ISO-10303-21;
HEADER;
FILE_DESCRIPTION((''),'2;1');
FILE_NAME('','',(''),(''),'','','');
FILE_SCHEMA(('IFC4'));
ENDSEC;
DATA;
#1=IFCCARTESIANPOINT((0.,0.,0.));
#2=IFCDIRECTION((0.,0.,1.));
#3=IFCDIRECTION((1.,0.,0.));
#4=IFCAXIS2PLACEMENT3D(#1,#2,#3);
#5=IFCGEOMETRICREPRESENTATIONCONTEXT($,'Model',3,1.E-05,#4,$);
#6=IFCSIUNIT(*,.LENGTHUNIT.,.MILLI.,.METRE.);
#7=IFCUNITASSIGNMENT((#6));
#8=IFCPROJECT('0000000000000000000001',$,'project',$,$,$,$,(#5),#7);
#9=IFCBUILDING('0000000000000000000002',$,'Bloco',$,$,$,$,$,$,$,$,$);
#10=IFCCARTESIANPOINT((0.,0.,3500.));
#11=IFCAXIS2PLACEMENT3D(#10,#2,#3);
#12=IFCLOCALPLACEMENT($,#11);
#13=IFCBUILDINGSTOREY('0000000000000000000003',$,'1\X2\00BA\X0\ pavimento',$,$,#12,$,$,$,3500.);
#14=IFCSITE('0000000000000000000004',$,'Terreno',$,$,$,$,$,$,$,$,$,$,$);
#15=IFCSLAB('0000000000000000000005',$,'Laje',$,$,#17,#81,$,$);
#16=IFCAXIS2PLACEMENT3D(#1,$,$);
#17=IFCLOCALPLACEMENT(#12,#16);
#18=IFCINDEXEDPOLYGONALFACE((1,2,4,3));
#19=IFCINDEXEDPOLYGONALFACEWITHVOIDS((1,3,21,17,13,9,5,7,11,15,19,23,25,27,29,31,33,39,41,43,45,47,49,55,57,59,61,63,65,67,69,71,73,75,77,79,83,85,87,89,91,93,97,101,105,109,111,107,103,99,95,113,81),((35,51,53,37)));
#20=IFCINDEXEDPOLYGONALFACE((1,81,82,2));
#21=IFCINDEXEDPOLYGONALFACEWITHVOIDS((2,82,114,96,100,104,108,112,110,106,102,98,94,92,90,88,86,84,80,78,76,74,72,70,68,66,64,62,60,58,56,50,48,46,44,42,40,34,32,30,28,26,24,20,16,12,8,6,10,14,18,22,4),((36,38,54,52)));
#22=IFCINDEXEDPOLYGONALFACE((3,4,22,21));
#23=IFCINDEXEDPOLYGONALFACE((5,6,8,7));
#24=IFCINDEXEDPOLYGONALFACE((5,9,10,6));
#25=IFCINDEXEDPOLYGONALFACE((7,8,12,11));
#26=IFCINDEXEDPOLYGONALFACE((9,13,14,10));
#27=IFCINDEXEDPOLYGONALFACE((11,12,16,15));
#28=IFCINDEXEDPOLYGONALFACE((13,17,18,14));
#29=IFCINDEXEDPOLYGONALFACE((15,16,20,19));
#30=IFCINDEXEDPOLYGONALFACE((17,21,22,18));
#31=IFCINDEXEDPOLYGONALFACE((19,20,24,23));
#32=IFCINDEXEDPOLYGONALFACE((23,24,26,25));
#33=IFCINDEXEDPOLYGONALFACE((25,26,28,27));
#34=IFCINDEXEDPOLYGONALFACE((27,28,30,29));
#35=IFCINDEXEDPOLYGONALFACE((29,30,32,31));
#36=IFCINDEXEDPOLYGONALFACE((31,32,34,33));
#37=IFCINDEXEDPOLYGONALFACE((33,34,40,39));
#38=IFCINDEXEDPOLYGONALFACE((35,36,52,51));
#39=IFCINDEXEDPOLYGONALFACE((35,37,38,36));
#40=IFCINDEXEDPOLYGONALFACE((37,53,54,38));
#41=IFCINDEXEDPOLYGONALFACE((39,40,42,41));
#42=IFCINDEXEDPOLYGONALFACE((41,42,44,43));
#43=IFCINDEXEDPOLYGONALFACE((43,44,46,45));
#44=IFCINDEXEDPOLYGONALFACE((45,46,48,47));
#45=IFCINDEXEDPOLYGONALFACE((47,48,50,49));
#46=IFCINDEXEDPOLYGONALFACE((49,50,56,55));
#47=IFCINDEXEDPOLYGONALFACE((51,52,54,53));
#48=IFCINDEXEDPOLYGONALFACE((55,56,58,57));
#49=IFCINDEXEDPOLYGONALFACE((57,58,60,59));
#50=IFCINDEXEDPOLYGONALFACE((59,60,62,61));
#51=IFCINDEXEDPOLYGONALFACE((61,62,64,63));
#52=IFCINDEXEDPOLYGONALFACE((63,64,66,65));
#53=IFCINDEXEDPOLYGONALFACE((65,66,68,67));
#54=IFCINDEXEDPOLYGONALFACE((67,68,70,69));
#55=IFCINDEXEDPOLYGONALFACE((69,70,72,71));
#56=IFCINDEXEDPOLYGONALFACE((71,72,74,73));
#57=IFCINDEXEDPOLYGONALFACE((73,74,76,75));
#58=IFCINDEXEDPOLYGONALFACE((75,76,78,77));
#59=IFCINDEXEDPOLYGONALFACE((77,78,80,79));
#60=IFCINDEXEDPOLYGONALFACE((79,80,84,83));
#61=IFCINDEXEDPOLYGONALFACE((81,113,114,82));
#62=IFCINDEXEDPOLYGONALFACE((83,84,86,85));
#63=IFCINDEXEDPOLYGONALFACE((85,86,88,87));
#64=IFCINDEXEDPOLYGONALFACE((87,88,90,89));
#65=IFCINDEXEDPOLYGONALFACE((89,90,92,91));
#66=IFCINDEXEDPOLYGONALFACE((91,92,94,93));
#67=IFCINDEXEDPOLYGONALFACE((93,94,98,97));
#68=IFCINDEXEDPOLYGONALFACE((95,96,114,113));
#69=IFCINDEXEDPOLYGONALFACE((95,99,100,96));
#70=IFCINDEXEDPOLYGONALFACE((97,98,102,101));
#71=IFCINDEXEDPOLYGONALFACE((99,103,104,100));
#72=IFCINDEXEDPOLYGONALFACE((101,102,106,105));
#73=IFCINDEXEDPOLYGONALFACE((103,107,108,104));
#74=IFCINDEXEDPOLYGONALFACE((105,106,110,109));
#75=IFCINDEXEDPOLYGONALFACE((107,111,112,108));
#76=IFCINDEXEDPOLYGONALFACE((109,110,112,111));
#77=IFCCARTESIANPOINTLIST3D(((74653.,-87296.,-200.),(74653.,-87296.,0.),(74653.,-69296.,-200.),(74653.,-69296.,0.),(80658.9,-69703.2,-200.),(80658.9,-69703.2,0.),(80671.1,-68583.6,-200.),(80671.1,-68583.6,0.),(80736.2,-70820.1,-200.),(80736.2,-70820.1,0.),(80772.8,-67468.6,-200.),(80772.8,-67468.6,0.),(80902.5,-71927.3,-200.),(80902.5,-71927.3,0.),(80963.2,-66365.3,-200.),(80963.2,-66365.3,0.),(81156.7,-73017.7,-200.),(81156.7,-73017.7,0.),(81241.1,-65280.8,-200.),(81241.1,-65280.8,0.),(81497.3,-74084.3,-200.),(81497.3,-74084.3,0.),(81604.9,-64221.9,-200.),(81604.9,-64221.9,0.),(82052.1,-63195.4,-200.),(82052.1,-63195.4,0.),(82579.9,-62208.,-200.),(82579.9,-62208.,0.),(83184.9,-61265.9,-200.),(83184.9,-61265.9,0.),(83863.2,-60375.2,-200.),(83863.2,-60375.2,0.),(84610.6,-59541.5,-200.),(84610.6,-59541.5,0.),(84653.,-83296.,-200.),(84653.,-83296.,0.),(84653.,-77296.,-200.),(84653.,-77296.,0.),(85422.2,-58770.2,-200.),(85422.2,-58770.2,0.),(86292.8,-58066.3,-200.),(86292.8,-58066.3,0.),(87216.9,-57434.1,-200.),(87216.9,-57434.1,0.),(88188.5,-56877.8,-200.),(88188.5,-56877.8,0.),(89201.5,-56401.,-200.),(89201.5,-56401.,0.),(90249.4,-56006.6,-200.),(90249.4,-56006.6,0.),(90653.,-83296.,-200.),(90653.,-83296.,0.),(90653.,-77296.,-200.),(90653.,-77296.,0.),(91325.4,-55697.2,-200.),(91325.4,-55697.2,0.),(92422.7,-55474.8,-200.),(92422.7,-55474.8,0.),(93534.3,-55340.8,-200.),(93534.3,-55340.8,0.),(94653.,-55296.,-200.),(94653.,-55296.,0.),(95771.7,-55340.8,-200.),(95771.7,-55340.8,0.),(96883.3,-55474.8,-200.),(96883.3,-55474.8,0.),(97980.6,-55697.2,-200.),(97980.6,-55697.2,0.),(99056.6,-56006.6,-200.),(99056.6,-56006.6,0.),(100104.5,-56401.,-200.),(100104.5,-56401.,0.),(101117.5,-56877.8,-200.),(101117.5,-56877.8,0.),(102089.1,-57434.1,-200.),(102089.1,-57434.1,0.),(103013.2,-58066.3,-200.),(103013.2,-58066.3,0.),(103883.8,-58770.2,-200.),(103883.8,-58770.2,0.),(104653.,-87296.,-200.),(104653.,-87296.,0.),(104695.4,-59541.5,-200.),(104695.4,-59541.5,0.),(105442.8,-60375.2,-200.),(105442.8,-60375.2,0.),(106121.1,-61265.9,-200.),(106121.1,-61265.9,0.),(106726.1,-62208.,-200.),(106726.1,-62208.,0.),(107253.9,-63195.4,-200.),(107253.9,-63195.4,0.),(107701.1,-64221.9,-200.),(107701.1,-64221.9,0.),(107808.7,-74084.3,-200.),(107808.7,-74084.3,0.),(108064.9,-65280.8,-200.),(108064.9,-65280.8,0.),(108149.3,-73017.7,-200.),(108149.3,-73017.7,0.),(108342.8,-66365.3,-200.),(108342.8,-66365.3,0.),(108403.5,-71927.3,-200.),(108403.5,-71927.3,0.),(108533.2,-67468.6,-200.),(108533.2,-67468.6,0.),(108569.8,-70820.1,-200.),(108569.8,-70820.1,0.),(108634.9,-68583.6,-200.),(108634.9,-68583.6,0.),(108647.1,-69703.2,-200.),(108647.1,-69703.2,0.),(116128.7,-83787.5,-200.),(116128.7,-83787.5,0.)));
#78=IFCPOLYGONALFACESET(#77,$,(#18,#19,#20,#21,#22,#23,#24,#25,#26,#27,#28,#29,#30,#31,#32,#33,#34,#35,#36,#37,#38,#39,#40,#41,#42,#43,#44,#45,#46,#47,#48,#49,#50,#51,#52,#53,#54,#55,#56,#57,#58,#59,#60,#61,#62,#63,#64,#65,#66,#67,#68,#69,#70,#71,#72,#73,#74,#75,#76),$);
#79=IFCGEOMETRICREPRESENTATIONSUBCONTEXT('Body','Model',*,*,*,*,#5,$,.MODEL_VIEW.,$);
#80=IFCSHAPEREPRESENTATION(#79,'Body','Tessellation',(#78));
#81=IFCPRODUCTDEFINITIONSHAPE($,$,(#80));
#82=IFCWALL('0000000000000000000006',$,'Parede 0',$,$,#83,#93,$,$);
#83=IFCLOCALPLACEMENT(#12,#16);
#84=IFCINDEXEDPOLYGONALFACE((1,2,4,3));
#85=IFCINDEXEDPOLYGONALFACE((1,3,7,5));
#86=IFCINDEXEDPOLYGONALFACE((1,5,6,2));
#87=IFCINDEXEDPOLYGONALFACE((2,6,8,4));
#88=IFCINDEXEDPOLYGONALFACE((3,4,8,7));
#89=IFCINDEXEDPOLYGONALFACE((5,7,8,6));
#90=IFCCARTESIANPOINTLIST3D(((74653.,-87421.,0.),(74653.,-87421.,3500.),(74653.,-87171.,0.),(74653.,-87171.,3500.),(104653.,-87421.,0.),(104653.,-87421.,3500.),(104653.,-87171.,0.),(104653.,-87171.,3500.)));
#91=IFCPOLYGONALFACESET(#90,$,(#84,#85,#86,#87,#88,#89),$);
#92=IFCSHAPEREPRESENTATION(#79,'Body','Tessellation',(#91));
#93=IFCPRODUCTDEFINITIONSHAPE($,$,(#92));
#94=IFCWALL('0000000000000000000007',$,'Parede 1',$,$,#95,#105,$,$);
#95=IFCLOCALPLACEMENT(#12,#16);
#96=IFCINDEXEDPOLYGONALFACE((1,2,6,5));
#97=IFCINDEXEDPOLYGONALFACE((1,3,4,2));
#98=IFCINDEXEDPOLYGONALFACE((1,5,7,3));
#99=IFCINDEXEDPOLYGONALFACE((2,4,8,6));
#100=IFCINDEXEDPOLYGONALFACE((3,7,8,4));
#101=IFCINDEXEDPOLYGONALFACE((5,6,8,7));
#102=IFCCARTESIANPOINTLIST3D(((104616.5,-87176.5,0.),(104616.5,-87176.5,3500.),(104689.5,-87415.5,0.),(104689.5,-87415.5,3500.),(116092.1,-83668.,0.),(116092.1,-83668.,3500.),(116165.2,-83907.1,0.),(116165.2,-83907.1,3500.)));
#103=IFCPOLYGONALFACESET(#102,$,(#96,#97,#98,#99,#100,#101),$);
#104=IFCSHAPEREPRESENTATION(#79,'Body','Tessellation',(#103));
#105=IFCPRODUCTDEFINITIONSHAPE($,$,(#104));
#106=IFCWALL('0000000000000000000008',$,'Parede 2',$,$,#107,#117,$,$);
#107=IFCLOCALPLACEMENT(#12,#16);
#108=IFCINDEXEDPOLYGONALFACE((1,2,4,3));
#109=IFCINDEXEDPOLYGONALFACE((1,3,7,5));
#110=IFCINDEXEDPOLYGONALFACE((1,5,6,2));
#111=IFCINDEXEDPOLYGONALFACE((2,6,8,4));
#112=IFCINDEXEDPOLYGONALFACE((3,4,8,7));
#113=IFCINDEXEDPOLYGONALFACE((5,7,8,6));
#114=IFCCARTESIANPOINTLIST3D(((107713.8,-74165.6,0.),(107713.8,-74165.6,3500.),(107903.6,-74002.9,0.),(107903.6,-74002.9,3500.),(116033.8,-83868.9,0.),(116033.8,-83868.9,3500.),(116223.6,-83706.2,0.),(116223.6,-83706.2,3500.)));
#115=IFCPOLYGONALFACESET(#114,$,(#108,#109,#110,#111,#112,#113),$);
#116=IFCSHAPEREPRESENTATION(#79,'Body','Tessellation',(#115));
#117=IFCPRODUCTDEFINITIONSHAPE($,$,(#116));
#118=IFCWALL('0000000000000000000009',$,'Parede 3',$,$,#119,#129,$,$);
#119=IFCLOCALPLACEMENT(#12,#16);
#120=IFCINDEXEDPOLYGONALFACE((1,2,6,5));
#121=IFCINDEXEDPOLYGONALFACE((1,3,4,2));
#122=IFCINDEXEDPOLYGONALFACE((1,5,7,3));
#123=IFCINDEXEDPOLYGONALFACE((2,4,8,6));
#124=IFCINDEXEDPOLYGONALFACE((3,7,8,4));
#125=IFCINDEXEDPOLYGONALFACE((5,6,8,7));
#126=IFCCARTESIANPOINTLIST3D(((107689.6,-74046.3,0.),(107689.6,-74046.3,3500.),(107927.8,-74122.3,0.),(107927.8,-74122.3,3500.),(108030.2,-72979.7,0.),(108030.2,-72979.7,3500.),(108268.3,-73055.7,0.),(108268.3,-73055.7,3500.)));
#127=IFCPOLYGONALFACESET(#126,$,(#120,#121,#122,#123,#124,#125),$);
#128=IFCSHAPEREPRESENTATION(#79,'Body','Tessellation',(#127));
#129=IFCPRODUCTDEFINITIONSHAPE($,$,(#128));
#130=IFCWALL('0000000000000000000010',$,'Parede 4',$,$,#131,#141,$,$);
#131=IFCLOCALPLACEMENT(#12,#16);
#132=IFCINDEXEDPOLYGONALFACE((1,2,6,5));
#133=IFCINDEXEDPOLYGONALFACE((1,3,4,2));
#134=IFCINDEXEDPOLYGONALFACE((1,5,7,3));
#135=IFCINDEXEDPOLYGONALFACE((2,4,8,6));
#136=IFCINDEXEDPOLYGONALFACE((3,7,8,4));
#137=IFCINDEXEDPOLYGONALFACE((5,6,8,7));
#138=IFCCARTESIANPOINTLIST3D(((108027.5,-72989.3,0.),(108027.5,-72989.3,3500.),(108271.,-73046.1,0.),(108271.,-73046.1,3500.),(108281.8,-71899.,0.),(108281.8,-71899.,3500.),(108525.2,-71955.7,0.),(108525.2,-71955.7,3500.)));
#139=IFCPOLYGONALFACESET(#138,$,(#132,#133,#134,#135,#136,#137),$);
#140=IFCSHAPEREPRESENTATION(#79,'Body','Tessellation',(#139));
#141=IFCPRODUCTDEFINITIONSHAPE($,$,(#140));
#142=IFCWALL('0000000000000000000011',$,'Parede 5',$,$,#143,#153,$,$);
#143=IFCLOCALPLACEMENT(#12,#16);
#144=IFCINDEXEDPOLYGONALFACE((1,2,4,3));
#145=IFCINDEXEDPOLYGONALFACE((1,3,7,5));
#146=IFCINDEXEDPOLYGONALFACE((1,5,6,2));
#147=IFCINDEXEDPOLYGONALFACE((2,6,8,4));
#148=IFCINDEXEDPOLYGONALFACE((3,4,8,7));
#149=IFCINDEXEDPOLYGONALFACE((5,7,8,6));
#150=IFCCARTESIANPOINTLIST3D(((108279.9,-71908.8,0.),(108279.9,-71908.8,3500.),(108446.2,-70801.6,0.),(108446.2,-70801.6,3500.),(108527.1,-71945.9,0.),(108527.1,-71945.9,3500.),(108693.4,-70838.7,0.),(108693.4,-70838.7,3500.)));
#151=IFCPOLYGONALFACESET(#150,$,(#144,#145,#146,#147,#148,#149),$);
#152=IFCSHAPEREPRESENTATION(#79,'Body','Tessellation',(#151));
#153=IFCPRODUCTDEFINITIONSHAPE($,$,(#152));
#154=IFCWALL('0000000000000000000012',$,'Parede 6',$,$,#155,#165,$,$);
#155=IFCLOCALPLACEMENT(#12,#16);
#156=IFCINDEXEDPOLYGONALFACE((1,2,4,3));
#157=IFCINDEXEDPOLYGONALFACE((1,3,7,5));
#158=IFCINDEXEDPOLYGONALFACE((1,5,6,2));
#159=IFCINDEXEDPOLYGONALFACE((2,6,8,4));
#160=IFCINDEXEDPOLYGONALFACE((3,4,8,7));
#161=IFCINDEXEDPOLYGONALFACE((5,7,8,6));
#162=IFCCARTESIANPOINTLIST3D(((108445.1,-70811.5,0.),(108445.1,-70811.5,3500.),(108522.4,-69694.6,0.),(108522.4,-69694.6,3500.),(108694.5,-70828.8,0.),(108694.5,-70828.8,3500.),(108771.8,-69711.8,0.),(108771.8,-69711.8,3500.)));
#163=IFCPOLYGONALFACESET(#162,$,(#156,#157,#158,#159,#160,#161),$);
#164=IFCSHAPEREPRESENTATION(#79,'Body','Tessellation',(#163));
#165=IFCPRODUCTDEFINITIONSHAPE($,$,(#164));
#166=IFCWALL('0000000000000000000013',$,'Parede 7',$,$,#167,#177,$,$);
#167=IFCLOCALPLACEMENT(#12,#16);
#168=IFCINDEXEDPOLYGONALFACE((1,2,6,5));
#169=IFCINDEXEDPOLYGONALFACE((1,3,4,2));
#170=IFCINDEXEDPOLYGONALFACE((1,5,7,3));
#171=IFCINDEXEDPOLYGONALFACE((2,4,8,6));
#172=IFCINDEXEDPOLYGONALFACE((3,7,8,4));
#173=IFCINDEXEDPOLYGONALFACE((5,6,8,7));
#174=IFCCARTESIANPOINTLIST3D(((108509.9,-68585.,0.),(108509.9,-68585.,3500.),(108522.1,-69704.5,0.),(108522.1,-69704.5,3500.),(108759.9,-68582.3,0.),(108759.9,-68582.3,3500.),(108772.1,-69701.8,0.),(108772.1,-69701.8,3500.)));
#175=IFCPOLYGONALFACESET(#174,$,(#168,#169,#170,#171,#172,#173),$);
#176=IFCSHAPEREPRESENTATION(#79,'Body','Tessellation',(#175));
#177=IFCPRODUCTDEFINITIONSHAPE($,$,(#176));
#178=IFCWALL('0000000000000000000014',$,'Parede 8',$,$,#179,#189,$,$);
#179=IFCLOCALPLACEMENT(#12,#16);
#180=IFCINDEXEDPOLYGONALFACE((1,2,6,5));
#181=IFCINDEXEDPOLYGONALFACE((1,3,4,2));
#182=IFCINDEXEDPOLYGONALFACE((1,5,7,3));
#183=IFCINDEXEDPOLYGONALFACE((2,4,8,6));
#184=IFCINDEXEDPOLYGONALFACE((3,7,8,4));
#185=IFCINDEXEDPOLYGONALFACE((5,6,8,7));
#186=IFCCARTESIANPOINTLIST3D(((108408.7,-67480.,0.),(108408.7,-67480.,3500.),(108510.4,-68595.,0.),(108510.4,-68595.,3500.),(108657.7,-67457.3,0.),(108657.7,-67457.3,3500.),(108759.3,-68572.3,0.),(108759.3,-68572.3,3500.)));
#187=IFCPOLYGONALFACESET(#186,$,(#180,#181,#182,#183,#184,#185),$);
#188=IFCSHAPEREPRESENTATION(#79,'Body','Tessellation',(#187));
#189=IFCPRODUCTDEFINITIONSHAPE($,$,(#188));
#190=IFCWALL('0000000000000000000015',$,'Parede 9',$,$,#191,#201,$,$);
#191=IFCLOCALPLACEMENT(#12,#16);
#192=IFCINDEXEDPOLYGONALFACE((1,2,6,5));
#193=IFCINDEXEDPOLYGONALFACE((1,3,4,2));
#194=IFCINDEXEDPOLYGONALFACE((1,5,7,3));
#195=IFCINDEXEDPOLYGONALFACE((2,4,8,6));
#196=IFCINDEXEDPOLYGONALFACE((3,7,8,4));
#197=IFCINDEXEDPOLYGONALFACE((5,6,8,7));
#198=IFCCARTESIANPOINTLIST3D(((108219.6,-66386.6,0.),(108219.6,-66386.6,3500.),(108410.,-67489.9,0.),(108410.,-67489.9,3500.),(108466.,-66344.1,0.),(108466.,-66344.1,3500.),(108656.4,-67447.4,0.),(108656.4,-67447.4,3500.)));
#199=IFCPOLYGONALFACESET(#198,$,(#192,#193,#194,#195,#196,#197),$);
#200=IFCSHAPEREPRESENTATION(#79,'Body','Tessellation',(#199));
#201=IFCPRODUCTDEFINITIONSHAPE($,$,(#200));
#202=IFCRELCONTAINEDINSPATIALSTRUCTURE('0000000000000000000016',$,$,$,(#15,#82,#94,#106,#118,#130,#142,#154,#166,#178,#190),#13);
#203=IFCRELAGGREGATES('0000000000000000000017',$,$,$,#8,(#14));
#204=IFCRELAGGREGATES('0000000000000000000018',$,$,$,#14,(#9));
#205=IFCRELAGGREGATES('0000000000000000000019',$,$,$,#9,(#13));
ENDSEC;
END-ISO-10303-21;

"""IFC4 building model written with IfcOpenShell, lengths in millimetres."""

from ifc_helpers import new_model, si_unit, frame, origin, origin_with_axes, place, context, subcontext, project, spatial, polyline, outline, extrude, element, save


model = new_model("IFC4")

# Units and contexts
model_context = context("Model", 3, precision=1e-05, world=origin_with_axes())
body_context = subcontext(model_context, "Body", "Model", "MODEL_VIEW")
ifc_project = project(units=[si_unit("LENGTHUNIT", "METRE", prefix="MILLI")], contexts=[model_context])

# Site, building, storey
site = spatial("IfcSite", under=ifc_project, Name="Terreno")
building = spatial("IfcBuilding", under=site, Name="Bloco")
storey_placement = place(None, frame((0.0, 0.0, 3500.0), z_axis=(0.0, 0.0, 1.0), x_axis=(1.0, 0.0, 0.0)))
storey = spatial("IfcBuildingStorey", under=building, at=storey_placement, Name="1º pavimento", Elevation=3500.0)

# Slab
slab_placement = place(storey_placement, frame((0.0, 0.0, -200.0), z_axis=(0.0, 0.0, 1.0), x_axis=(1.0, 0.0, 0.0)))
element("IfcSlab", 1, at=slab_placement, inside=storey, Name="Laje", context=body_context, shape_type="SweptSolid", body=[
    extrude(outline(polyline([(74653.0, -87296.0), (104653.0, -87296.0), (116128.7, -83787.5), (107808.7, -74084.3), (108149.3, -73017.7), (108403.5, -71927.3), (108569.8, -70820.1), (108647.1, -69703.2), (108634.9, -68583.6), (108533.2, -67468.6), (108342.8, -66365.3), (108064.9, -65280.8), (107701.1, -64221.9), (107253.9, -63195.4), (106726.1, -62208.0), (106121.1, -61265.9), (105442.8, -60375.2), (104695.4, -59541.5), (103883.8, -58770.2), (103013.2, -58066.3), (102089.1, -57434.1), (101117.5, -56877.8), (100104.5, -56401.0), (99056.6, -56006.6), (97980.6, -55697.2), (96883.3, -55474.8), (95771.7, -55340.8), (94653.0, -55296.0), (93534.3, -55340.8), (92422.7, -55474.8), (91325.4, -55697.2), (90249.4, -56006.6), (89201.5, -56401.0), (88188.5, -56877.8), (87216.9, -57434.1), (86292.8, -58066.3), (85422.2, -58770.2), (84610.6, -59541.5), (83863.2, -60375.2), (83184.9, -61265.9), (82579.9, -62208.0), (82052.1, -63195.4), (81604.9, -64221.9), (81241.1, -65280.8), (80963.2, -66365.3), (80772.8, -67468.6), (80671.1, -68583.6), (80658.9, -69703.2), (80736.2, -70820.1), (80902.5, -71927.3), (81156.7, -73017.7), (81497.3, -74084.3), (74653.0, -69296.0), (74653.0, -87296.0)]), holes=[polyline([(84653.0, -83296.0), (90653.0, -83296.0), (90653.0, -77296.0), (84653.0, -77296.0), (84653.0, -83296.0)])]), origin(), (0.0, 0.0, 1.0), 200.0),
])

# Walls
wall_1_placement = place(storey_placement, origin_with_axes())
element("IfcWall", 2, at=wall_1_placement, inside=storey, Name="Parede 0", context=body_context, shape_type="SweptSolid", body=[
    extrude(outline(polyline([(74653.0, -87171.0), (104653.0, -87171.0), (104653.0, -87421.0), (74653.0, -87421.0), (74653.0, -87171.0)])), origin(), (0.0, 0.0, 1.0), 3500.0),
])
wall_2_placement = place(storey_placement, origin_with_axes())
element("IfcWall", 3, at=wall_2_placement, inside=storey, Name="Parede 1", context=body_context, shape_type="SweptSolid", body=[
    extrude(outline(polyline([(104616.5, -87176.5), (116092.1, -83668.0), (116165.2, -83907.1), (104689.5, -87415.5), (104616.5, -87176.5)])), origin(), (0.0, 0.0, 1.0), 3500.0),
])
wall_3_placement = place(storey_placement, origin_with_axes())
element("IfcWall", 4, at=wall_3_placement, inside=storey, Name="Parede 2", context=body_context, shape_type="SweptSolid", body=[
    extrude(outline(polyline([(116033.8, -83868.9), (107713.8, -74165.6), (107903.6, -74002.9), (116223.6, -83706.2), (116033.8, -83868.9)])), origin(), (0.0, 0.0, 1.0), 3500.0),
])
wall_4_placement = place(storey_placement, origin_with_axes())
element("IfcWall", 5, at=wall_4_placement, inside=storey, Name="Parede 3", context=body_context, shape_type="SweptSolid", body=[
    extrude(outline(polyline([(107689.6, -74046.3), (108030.2, -72979.7), (108268.3, -73055.7), (107927.8, -74122.3), (107689.6, -74046.3)])), origin(), (0.0, 0.0, 1.0), 3500.0),
])
wall_5_placement = place(storey_placement, origin_with_axes())
element("IfcWall", 6, at=wall_5_placement, inside=storey, Name="Parede 4", context=body_context, shape_type="SweptSolid", body=[
    extrude(outline(polyline([(108027.5, -72989.3), (108281.8, -71899.0), (108525.2, -71955.7), (108271.0, -73046.1), (108027.5, -72989.3)])), origin(), (0.0, 0.0, 1.0), 3500.0),
])
wall_6_placement = place(storey_placement, origin_with_axes())
element("IfcWall", 7, at=wall_6_placement, inside=storey, Name="Parede 5", context=body_context, shape_type="SweptSolid", body=[
    extrude(outline(polyline([(108279.9, -71908.8), (108446.2, -70801.6), (108693.4, -70838.7), (108527.1, -71945.9), (108279.9, -71908.8)])), origin(), (0.0, 0.0, 1.0), 3500.0),
])
wall_7_placement = place(storey_placement, origin_with_axes())
element("IfcWall", 8, at=wall_7_placement, inside=storey, Name="Parede 6", context=body_context, shape_type="SweptSolid", body=[
    extrude(outline(polyline([(108445.1, -70811.5), (108522.4, -69694.6), (108771.8, -69711.8), (108694.5, -70828.8), (108445.1, -70811.5)])), origin(), (0.0, 0.0, 1.0), 3500.0),
])
wall_8_placement = place(storey_placement, origin_with_axes())
element("IfcWall", 9, at=wall_8_placement, inside=storey, Name="Parede 7", context=body_context, shape_type="SweptSolid", body=[
    extrude(outline(polyline([(108522.1, -69704.5), (108509.9, -68585.0), (108759.9, -68582.3), (108772.1, -69701.8), (108522.1, -69704.5)])), origin(), (0.0, 0.0, 1.0), 3500.0),
])
wall_9_placement = place(storey_placement, origin_with_axes())
element("IfcWall", 10, at=wall_9_placement, inside=storey, Name="Parede 8", context=body_context, shape_type="SweptSolid", body=[
    extrude(outline(polyline([(108510.4, -68595.0), (108408.7, -67480.0), (108657.7, -67457.3), (108759.3, -68572.3), (108510.4, -68595.0)])), origin(), (0.0, 0.0, 1.0), 3500.0),
])
wall_10_placement = place(storey_placement, origin_with_axes())
element("IfcWall", 11, at=wall_10_placement, inside=storey, Name="Parede 9", context=body_context, shape_type="SweptSolid", body=[
    extrude(outline(polyline([(108410.0, -67489.9), (108219.6, -66386.6), (108466.0, -66344.1), (108656.4, -67447.4), (108410.0, -67489.9)])), origin(), (0.0, 0.0, 1.0), 3500.0),
])

save(model, "model.ifc")
